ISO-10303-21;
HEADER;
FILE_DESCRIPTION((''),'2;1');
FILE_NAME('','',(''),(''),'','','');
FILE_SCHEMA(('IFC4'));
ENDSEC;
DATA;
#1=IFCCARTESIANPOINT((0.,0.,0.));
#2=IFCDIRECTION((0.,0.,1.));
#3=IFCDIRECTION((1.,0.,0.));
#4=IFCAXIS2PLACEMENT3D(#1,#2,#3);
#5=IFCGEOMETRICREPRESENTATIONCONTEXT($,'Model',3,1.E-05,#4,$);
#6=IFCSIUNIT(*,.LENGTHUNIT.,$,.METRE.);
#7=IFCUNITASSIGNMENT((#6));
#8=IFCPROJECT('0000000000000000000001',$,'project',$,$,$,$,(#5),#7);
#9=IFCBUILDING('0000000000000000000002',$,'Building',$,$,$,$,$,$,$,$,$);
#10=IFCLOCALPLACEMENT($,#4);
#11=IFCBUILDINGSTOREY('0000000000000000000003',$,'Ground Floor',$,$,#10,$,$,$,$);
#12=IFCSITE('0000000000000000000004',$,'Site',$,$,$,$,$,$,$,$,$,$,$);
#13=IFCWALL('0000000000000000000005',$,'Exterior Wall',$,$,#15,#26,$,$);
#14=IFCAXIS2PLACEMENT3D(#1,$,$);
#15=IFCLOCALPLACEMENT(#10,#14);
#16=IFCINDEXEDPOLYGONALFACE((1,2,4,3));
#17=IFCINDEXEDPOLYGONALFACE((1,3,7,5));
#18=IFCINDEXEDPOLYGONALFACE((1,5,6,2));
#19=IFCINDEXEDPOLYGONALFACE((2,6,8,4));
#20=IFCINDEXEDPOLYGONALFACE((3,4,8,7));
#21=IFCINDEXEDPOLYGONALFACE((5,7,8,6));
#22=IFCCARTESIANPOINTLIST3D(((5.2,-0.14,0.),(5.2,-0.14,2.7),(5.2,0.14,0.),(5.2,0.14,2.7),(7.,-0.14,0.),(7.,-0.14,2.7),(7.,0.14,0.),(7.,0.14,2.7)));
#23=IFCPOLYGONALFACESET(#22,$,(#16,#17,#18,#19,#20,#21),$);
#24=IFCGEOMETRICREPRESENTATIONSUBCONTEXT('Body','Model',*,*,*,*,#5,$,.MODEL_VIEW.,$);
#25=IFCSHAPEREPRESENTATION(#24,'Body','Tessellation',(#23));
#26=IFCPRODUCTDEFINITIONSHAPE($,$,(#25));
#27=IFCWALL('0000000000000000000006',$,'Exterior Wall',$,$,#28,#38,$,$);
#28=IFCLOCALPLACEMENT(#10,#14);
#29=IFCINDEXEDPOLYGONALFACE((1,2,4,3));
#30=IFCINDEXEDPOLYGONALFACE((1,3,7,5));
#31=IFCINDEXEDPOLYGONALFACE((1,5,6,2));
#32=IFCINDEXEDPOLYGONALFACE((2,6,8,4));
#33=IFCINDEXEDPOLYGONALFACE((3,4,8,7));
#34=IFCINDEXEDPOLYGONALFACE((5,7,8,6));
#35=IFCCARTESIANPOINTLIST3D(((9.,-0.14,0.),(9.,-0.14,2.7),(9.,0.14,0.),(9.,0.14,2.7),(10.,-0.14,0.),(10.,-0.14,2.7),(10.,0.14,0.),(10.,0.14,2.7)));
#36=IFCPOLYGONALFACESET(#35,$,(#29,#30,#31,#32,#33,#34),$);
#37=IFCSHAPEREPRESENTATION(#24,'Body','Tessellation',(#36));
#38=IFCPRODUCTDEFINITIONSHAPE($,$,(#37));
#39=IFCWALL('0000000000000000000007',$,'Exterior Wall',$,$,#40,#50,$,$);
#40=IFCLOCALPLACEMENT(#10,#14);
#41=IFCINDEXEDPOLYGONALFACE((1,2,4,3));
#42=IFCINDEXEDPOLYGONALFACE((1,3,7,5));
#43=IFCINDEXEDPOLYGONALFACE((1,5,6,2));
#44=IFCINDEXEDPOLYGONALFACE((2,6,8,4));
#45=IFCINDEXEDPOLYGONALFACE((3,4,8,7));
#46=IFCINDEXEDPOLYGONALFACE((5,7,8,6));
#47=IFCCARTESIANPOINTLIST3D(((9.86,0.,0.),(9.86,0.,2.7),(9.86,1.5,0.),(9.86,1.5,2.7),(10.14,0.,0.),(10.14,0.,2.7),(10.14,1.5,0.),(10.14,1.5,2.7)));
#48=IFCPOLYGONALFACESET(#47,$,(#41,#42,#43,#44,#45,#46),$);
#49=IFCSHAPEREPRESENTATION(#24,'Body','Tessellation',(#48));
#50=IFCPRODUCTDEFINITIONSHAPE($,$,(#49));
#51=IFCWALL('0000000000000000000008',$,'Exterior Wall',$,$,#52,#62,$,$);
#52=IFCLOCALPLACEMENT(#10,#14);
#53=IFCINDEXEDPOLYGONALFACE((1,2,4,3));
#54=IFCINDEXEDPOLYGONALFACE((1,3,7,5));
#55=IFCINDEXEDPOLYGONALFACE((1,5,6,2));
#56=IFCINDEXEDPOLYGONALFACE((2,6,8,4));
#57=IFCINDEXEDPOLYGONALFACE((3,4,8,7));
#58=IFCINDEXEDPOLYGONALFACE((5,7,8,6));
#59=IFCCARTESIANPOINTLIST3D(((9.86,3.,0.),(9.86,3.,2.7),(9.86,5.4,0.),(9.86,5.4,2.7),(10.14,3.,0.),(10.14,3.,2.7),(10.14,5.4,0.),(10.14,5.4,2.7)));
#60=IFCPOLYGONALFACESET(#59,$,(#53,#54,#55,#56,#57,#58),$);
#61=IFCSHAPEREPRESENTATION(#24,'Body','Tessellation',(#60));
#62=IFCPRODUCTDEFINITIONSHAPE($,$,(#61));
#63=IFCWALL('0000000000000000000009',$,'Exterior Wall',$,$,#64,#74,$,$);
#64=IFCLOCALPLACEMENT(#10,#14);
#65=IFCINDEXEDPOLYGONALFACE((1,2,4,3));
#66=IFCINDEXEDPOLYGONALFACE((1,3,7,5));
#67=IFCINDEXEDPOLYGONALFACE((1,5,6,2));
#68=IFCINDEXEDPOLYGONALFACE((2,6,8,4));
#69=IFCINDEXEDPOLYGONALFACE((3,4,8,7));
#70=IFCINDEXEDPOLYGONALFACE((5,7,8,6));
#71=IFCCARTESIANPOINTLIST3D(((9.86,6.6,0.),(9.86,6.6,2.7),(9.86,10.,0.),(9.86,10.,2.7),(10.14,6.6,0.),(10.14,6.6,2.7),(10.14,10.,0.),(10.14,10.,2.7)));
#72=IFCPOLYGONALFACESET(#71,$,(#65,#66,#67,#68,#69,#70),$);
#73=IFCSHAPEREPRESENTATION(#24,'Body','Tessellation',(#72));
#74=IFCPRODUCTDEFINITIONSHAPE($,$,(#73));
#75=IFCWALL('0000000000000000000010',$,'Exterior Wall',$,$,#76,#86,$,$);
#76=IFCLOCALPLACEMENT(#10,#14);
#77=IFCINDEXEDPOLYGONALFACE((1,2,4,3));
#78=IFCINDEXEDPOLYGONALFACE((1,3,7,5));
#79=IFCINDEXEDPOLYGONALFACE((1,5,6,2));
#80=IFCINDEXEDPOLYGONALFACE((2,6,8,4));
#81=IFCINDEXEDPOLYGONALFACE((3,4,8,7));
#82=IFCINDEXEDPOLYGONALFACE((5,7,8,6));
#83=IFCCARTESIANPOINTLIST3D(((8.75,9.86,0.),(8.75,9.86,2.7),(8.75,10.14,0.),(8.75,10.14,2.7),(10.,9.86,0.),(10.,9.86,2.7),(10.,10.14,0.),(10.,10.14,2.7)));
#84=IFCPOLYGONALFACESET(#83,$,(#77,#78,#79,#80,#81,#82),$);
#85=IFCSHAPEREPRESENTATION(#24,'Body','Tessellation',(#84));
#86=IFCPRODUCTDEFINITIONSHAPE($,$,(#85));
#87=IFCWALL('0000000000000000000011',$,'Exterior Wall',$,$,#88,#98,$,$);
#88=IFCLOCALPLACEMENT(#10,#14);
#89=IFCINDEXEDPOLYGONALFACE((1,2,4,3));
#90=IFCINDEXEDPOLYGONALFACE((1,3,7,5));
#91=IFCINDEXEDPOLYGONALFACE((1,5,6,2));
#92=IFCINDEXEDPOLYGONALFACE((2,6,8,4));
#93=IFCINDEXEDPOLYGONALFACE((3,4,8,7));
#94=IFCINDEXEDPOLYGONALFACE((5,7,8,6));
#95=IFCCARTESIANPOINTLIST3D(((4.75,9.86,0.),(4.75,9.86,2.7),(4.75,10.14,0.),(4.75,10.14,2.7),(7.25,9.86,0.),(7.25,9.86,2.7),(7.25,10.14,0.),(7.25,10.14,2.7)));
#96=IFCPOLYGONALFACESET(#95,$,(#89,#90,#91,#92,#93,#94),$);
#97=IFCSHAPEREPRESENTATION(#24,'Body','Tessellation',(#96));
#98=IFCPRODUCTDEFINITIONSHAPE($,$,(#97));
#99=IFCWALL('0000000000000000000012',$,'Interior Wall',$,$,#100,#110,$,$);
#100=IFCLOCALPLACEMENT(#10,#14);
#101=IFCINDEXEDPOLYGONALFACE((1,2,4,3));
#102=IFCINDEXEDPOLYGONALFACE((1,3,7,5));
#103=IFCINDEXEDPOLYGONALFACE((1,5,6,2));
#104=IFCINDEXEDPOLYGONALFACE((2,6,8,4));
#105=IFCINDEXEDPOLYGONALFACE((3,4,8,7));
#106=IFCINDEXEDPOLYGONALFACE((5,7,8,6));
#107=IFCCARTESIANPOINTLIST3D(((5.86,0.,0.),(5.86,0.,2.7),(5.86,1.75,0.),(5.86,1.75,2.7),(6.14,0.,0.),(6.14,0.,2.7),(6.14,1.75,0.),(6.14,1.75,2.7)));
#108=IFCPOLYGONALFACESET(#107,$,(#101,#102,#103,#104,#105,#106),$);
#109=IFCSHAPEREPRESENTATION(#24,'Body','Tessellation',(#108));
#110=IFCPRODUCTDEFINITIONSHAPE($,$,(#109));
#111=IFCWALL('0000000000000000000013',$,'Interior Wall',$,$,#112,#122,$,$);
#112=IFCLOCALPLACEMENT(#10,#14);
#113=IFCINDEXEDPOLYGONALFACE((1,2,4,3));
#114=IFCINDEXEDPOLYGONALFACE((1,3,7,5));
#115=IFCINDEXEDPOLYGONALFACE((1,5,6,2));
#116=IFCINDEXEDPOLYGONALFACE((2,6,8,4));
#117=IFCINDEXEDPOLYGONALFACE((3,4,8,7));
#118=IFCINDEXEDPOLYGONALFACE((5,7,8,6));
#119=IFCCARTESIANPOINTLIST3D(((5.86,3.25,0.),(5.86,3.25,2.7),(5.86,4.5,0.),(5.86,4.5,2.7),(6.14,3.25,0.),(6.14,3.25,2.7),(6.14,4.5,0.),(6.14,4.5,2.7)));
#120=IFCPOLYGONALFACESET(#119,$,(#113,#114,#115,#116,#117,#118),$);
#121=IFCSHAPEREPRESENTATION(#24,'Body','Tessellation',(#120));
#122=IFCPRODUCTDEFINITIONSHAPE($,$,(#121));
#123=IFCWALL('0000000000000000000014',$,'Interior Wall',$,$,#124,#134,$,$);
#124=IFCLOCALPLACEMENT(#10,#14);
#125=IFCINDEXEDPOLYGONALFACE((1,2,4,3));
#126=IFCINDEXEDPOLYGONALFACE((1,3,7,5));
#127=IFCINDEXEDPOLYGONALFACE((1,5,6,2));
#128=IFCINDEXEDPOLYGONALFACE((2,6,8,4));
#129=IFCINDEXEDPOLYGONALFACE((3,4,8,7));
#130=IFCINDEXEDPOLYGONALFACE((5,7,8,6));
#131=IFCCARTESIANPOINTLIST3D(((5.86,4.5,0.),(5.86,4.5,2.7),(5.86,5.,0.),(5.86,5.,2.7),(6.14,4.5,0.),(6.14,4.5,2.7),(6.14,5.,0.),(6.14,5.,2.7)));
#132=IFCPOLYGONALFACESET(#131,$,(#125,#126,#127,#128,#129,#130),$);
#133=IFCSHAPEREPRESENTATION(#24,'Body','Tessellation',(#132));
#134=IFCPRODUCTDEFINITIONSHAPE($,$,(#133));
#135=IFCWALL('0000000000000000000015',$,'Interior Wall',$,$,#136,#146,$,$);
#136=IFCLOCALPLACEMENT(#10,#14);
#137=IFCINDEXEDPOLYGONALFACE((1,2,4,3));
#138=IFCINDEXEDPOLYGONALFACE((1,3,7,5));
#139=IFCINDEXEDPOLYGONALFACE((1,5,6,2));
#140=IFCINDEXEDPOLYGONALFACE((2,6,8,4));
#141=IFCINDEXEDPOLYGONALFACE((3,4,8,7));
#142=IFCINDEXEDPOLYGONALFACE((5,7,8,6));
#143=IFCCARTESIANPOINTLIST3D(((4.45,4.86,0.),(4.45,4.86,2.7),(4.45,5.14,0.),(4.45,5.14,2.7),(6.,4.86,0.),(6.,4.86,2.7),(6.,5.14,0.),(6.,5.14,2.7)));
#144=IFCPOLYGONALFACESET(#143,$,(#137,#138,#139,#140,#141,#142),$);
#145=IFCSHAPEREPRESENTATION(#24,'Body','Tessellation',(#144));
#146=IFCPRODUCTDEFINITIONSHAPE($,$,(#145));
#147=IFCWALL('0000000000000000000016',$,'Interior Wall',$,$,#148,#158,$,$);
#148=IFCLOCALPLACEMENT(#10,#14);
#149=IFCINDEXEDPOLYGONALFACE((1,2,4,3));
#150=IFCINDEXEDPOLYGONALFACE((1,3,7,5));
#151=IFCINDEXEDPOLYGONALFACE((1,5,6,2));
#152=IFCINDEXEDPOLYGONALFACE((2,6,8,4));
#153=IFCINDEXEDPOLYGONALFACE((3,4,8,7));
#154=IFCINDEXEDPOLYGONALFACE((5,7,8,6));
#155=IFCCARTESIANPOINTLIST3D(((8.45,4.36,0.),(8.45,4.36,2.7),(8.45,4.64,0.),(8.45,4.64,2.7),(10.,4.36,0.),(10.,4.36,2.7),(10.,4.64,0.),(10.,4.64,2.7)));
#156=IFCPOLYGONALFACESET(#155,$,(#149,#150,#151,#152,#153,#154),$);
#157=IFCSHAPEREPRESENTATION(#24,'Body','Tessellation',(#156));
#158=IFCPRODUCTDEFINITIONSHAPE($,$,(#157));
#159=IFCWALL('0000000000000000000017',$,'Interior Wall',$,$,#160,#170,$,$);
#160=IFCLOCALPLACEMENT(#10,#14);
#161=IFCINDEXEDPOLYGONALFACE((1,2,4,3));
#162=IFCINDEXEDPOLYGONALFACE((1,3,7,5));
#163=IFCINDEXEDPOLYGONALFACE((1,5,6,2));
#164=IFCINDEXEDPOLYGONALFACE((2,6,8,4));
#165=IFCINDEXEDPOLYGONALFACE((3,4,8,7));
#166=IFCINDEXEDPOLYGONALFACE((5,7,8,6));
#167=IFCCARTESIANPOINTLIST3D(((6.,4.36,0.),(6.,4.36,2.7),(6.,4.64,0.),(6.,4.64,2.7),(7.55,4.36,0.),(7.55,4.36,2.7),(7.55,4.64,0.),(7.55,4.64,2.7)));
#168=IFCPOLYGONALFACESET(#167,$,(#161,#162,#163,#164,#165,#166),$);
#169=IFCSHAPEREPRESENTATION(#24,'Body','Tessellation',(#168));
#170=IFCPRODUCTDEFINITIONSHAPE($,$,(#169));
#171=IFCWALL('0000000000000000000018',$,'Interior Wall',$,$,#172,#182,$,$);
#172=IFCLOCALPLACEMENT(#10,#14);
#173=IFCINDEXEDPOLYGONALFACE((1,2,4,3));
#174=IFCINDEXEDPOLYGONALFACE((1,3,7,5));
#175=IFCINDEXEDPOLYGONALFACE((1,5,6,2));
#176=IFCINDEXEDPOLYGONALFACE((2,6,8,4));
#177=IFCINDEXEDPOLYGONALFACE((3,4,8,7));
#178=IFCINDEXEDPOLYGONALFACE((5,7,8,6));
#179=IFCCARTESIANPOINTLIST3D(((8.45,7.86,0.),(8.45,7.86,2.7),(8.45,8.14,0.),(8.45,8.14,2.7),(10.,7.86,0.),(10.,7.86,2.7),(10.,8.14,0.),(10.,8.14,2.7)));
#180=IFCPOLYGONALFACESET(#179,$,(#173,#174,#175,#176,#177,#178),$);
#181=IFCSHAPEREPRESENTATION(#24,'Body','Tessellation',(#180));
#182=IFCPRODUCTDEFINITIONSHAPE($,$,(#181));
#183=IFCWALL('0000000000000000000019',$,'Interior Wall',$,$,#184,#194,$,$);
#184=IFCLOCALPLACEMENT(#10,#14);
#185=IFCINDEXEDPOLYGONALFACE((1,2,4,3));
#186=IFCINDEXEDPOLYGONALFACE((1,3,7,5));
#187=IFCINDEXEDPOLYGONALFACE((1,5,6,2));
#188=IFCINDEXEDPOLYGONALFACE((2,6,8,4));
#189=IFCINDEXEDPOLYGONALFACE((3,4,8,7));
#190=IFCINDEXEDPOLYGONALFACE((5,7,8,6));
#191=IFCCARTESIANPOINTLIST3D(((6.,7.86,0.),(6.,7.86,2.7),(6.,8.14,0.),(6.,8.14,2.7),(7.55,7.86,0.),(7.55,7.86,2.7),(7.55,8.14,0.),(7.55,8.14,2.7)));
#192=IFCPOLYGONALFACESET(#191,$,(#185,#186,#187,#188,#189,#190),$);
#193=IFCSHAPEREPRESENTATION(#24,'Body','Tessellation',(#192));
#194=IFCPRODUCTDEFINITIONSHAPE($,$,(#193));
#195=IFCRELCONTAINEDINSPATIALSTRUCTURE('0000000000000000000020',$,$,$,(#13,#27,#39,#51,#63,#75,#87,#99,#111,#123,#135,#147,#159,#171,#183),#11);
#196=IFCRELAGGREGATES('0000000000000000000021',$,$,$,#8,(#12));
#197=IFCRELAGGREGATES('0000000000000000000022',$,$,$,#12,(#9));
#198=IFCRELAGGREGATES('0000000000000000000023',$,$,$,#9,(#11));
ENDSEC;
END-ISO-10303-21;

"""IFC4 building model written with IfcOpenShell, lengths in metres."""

from ifc_helpers import new_model, si_unit, frame, origin_with_axes, place, context, subcontext, project, spatial, indexed_curve, outline, extrude, element, save


model = new_model("IFC4")

# Units and contexts
model_context = context("Model", 3, precision=1e-05, world=origin_with_axes())
body_context = subcontext(model_context, "Body", "Model", "MODEL_VIEW")
ifc_project = project(units=[si_unit("LENGTHUNIT", "METRE")], contexts=[model_context])

# Site, building, storey
site = spatial("IfcSite", under=ifc_project, Name="Site")
building = spatial("IfcBuilding", under=site, Name="Building")
storey_placement = place(None, origin_with_axes())
storey = spatial("IfcBuildingStorey", under=building, at=storey_placement, Name="Ground Floor")

# Walls
wall_1_placement = place(storey_placement, frame((5.2, 0.0, 0.0), z_axis=(0.0, 0.0, 1.0), x_axis=(1.0, 0.0, 0.0)))
element("IfcWall", 1, at=wall_1_placement, inside=storey, Name="Exterior Wall", context=body_context, shape_type="SweptSolid", body=[
    extrude(outline(indexed_curve([(0.0, 0.0), (0.0, 0.28), (1.8, 0.28), (1.8, 0.0), (0.0, 0.0)], self_intersect=False)), frame((0.0, -0.14, 0.0), z_axis=(0.0, 0.0, 1.0), x_axis=(1.0, 0.0, 0.0)), (0.0, 0.0, 1.0), 2.7),
])
wall_2_placement = place(storey_placement, frame((9.0, 0.0, 0.0), z_axis=(0.0, 0.0, 1.0), x_axis=(1.0, 0.0, 0.0)))
element("IfcWall", 2, at=wall_2_placement, inside=storey, Name="Exterior Wall", context=body_context, shape_type="SweptSolid", body=[
    extrude(outline(indexed_curve([(0.0, 0.0), (0.0, 0.28), (1.0, 0.28), (1.0, 0.0), (0.0, 0.0)], self_intersect=False)), frame((0.0, -0.14, 0.0), z_axis=(0.0, 0.0, 1.0), x_axis=(1.0, 0.0, 0.0)), (0.0, 0.0, 1.0), 2.7),
])
wall_3_placement = place(storey_placement, frame((10.0, 0.0, 0.0), z_axis=(0.0, 0.0, 1.0), x_axis=(0.0, 1.0, 0.0)))
element("IfcWall", 3, at=wall_3_placement, inside=storey, Name="Exterior Wall", context=body_context, shape_type="SweptSolid", body=[
    extrude(outline(indexed_curve([(0.0, 0.0), (0.0, 0.28), (1.5, 0.28), (1.5, 0.0), (0.0, 0.0)], self_intersect=False)), frame((0.0, -0.14, 0.0), z_axis=(0.0, 0.0, 1.0), x_axis=(1.0, 0.0, 0.0)), (0.0, 0.0, 1.0), 2.7),
])
wall_4_placement = place(storey_placement, frame((10.0, 3.0, 0.0), z_axis=(0.0, 0.0, 1.0), x_axis=(0.0, 1.0, 0.0)))
element("IfcWall", 4, at=wall_4_placement, inside=storey, Name="Exterior Wall", context=body_context, shape_type="SweptSolid", body=[
    extrude(outline(indexed_curve([(0.0, 0.0), (0.0, 0.28), (2.4, 0.28), (2.4, 0.0), (0.0, 0.0)], self_intersect=False)), frame((0.0, -0.14, 0.0), z_axis=(0.0, 0.0, 1.0), x_axis=(1.0, 0.0, 0.0)), (0.0, 0.0, 1.0), 2.7),
])
wall_5_placement = place(storey_placement, frame((10.0, 6.6, 0.0), z_axis=(0.0, 0.0, 1.0), x_axis=(0.0, 1.0, 0.0)))
element("IfcWall", 5, at=wall_5_placement, inside=storey, Name="Exterior Wall", context=body_context, shape_type="SweptSolid", body=[
    extrude(outline(indexed_curve([(0.0, 0.0), (0.0, 0.28), (3.4, 0.28), (3.4, 0.0), (0.0, 0.0)], self_intersect=False)), frame((0.0, -0.14, 0.0), z_axis=(0.0, 0.0, 1.0), x_axis=(1.0, 0.0, 0.0)), (0.0, 0.0, 1.0), 2.7),
])
wall_6_placement = place(storey_placement, frame((10.0, 10.0, 0.0), z_axis=(0.0, 0.0, 1.0), x_axis=(-1.0, 0.0, 0.0)))
element("IfcWall", 6, at=wall_6_placement, inside=storey, Name="Exterior Wall", context=body_context, shape_type="SweptSolid", body=[
    extrude(outline(indexed_curve([(0.0, 0.0), (0.0, 0.28), (1.25, 0.28), (1.25, 0.0), (0.0, 0.0)], self_intersect=False)), frame((0.0, -0.14, 0.0), z_axis=(0.0, 0.0, 1.0), x_axis=(1.0, 0.0, 0.0)), (0.0, 0.0, 1.0), 2.7),
])
wall_7_placement = place(storey_placement, frame((7.25, 10.0, 0.0), z_axis=(0.0, 0.0, 1.0), x_axis=(-1.0, 0.0, 0.0)))
element("IfcWall", 7, at=wall_7_placement, inside=storey, Name="Exterior Wall", context=body_context, shape_type="SweptSolid", body=[
    extrude(outline(indexed_curve([(0.0, 0.0), (0.0, 0.28), (2.5, 0.28), (2.5, 0.0), (0.0, 0.0)], self_intersect=False)), frame((0.0, -0.14, 0.0), z_axis=(0.0, 0.0, 1.0), x_axis=(1.0, 0.0, 0.0)), (0.0, 0.0, 1.0), 2.7),
])
wall_8_placement = place(storey_placement, frame((6.0, 0.0, 0.0), z_axis=(0.0, 0.0, 1.0), x_axis=(0.0, 1.0, 0.0)))
element("IfcWall", 8, at=wall_8_placement, inside=storey, Name="Interior Wall", context=body_context, shape_type="SweptSolid", body=[
    extrude(outline(indexed_curve([(0.0, 0.0), (0.0, 0.28), (1.75, 0.28), (1.75, 0.0), (0.0, 0.0)], self_intersect=False)), frame((0.0, -0.14, 0.0), z_axis=(0.0, 0.0, 1.0), x_axis=(1.0, 0.0, 0.0)), (0.0, 0.0, 1.0), 2.7),
])
wall_9_placement = place(storey_placement, frame((6.0, 3.25, 0.0), z_axis=(0.0, 0.0, 1.0), x_axis=(0.0, 1.0, 0.0)))
element("IfcWall", 9, at=wall_9_placement, inside=storey, Name="Interior Wall", context=body_context, shape_type="SweptSolid", body=[
    extrude(outline(indexed_curve([(0.0, 0.0), (0.0, 0.28), (1.25, 0.28), (1.25, 0.0), (0.0, 0.0)], self_intersect=False)), frame((0.0, -0.14, 0.0), z_axis=(0.0, 0.0, 1.0), x_axis=(1.0, 0.0, 0.0)), (0.0, 0.0, 1.0), 2.7),
])
wall_10_placement = place(storey_placement, frame((6.0, 4.5, 0.0), z_axis=(0.0, 0.0, 1.0), x_axis=(0.0, 1.0, 0.0)))
element("IfcWall", 10, at=wall_10_placement, inside=storey, Name="Interior Wall", context=body_context, shape_type="SweptSolid", body=[
    extrude(outline(indexed_curve([(0.0, 0.0), (0.0, 0.28), (0.5, 0.28), (0.5, 0.0), (0.0, 0.0)], self_intersect=False)), frame((0.0, -0.14, 0.0), z_axis=(0.0, 0.0, 1.0), x_axis=(1.0, 0.0, 0.0)), (0.0, 0.0, 1.0), 2.7),
])
wall_11_placement = place(storey_placement, frame((6.0, 5.0, 0.0), z_axis=(0.0, 0.0, 1.0), x_axis=(-1.0, 0.0, 0.0)))
element("IfcWall", 11, at=wall_11_placement, inside=storey, Name="Interior Wall", context=body_context, shape_type="SweptSolid", body=[
    extrude(outline(indexed_curve([(0.0, 0.0), (0.0, 0.28), (1.55, 0.28), (1.55, 0.0), (0.0, 0.0)], self_intersect=False)), frame((0.0, -0.14, 0.0), z_axis=(0.0, 0.0, 1.0), x_axis=(1.0, 0.0, 0.0)), (0.0, 0.0, 1.0), 2.7),
])
wall_12_placement = place(storey_placement, frame((10.0, 4.5, 0.0), z_axis=(0.0, 0.0, 1.0), x_axis=(-1.0, 0.0, 0.0)))
element("IfcWall", 12, at=wall_12_placement, inside=storey, Name="Interior Wall", context=body_context, shape_type="SweptSolid", body=[
    extrude(outline(indexed_curve([(0.0, 0.0), (0.0, 0.28), (1.55, 0.28), (1.55, 0.0), (0.0, 0.0)], self_intersect=False)), frame((0.0, -0.14, 0.0), z_axis=(0.0, 0.0, 1.0), x_axis=(1.0, 0.0, 0.0)), (0.0, 0.0, 1.0), 2.7),
])
wall_13_placement = place(storey_placement, frame((7.55, 4.5, 0.0), z_axis=(0.0, 0.0, 1.0), x_axis=(-1.0, 0.0, 0.0)))
element("IfcWall", 13, at=wall_13_placement, inside=storey, Name="Interior Wall", context=body_context, shape_type="SweptSolid", body=[
    extrude(outline(indexed_curve([(0.0, 0.0), (0.0, 0.28), (1.55, 0.28), (1.55, 0.0), (0.0, 0.0)], self_intersect=False)), frame((0.0, -0.14, 0.0), z_axis=(0.0, 0.0, 1.0), x_axis=(1.0, 0.0, 0.0)), (0.0, 0.0, 1.0), 2.7),
])
wall_14_placement = place(storey_placement, frame((10.0, 8.0, 0.0), z_axis=(0.0, 0.0, 1.0), x_axis=(-1.0, 0.0, 0.0)))
element("IfcWall", 14, at=wall_14_placement, inside=storey, Name="Interior Wall", context=body_context, shape_type="SweptSolid", body=[
    extrude(outline(indexed_curve([(0.0, 0.0), (0.0, 0.28), (1.55, 0.28), (1.55, 0.0), (0.0, 0.0)], self_intersect=False)), frame((0.0, -0.14, 0.0), z_axis=(0.0, 0.0, 1.0), x_axis=(1.0, 0.0, 0.0)), (0.0, 0.0, 1.0), 2.7),
])
wall_15_placement = place(storey_placement, frame((7.55, 8.0, 0.0), z_axis=(0.0, 0.0, 1.0), x_axis=(-1.0, 0.0, 0.0)))
element("IfcWall", 15, at=wall_15_placement, inside=storey, Name="Interior Wall", context=body_context, shape_type="SweptSolid", body=[
    extrude(outline(indexed_curve([(0.0, 0.0), (0.0, 0.28), (1.55, 0.28), (1.55, 0.0), (0.0, 0.0)], self_intersect=False)), frame((0.0, -0.14, 0.0), z_axis=(0.0, 0.0, 1.0), x_axis=(1.0, 0.0, 0.0)), (0.0, 0.0, 1.0), 2.7),
])

save(model, "model.ifc")
